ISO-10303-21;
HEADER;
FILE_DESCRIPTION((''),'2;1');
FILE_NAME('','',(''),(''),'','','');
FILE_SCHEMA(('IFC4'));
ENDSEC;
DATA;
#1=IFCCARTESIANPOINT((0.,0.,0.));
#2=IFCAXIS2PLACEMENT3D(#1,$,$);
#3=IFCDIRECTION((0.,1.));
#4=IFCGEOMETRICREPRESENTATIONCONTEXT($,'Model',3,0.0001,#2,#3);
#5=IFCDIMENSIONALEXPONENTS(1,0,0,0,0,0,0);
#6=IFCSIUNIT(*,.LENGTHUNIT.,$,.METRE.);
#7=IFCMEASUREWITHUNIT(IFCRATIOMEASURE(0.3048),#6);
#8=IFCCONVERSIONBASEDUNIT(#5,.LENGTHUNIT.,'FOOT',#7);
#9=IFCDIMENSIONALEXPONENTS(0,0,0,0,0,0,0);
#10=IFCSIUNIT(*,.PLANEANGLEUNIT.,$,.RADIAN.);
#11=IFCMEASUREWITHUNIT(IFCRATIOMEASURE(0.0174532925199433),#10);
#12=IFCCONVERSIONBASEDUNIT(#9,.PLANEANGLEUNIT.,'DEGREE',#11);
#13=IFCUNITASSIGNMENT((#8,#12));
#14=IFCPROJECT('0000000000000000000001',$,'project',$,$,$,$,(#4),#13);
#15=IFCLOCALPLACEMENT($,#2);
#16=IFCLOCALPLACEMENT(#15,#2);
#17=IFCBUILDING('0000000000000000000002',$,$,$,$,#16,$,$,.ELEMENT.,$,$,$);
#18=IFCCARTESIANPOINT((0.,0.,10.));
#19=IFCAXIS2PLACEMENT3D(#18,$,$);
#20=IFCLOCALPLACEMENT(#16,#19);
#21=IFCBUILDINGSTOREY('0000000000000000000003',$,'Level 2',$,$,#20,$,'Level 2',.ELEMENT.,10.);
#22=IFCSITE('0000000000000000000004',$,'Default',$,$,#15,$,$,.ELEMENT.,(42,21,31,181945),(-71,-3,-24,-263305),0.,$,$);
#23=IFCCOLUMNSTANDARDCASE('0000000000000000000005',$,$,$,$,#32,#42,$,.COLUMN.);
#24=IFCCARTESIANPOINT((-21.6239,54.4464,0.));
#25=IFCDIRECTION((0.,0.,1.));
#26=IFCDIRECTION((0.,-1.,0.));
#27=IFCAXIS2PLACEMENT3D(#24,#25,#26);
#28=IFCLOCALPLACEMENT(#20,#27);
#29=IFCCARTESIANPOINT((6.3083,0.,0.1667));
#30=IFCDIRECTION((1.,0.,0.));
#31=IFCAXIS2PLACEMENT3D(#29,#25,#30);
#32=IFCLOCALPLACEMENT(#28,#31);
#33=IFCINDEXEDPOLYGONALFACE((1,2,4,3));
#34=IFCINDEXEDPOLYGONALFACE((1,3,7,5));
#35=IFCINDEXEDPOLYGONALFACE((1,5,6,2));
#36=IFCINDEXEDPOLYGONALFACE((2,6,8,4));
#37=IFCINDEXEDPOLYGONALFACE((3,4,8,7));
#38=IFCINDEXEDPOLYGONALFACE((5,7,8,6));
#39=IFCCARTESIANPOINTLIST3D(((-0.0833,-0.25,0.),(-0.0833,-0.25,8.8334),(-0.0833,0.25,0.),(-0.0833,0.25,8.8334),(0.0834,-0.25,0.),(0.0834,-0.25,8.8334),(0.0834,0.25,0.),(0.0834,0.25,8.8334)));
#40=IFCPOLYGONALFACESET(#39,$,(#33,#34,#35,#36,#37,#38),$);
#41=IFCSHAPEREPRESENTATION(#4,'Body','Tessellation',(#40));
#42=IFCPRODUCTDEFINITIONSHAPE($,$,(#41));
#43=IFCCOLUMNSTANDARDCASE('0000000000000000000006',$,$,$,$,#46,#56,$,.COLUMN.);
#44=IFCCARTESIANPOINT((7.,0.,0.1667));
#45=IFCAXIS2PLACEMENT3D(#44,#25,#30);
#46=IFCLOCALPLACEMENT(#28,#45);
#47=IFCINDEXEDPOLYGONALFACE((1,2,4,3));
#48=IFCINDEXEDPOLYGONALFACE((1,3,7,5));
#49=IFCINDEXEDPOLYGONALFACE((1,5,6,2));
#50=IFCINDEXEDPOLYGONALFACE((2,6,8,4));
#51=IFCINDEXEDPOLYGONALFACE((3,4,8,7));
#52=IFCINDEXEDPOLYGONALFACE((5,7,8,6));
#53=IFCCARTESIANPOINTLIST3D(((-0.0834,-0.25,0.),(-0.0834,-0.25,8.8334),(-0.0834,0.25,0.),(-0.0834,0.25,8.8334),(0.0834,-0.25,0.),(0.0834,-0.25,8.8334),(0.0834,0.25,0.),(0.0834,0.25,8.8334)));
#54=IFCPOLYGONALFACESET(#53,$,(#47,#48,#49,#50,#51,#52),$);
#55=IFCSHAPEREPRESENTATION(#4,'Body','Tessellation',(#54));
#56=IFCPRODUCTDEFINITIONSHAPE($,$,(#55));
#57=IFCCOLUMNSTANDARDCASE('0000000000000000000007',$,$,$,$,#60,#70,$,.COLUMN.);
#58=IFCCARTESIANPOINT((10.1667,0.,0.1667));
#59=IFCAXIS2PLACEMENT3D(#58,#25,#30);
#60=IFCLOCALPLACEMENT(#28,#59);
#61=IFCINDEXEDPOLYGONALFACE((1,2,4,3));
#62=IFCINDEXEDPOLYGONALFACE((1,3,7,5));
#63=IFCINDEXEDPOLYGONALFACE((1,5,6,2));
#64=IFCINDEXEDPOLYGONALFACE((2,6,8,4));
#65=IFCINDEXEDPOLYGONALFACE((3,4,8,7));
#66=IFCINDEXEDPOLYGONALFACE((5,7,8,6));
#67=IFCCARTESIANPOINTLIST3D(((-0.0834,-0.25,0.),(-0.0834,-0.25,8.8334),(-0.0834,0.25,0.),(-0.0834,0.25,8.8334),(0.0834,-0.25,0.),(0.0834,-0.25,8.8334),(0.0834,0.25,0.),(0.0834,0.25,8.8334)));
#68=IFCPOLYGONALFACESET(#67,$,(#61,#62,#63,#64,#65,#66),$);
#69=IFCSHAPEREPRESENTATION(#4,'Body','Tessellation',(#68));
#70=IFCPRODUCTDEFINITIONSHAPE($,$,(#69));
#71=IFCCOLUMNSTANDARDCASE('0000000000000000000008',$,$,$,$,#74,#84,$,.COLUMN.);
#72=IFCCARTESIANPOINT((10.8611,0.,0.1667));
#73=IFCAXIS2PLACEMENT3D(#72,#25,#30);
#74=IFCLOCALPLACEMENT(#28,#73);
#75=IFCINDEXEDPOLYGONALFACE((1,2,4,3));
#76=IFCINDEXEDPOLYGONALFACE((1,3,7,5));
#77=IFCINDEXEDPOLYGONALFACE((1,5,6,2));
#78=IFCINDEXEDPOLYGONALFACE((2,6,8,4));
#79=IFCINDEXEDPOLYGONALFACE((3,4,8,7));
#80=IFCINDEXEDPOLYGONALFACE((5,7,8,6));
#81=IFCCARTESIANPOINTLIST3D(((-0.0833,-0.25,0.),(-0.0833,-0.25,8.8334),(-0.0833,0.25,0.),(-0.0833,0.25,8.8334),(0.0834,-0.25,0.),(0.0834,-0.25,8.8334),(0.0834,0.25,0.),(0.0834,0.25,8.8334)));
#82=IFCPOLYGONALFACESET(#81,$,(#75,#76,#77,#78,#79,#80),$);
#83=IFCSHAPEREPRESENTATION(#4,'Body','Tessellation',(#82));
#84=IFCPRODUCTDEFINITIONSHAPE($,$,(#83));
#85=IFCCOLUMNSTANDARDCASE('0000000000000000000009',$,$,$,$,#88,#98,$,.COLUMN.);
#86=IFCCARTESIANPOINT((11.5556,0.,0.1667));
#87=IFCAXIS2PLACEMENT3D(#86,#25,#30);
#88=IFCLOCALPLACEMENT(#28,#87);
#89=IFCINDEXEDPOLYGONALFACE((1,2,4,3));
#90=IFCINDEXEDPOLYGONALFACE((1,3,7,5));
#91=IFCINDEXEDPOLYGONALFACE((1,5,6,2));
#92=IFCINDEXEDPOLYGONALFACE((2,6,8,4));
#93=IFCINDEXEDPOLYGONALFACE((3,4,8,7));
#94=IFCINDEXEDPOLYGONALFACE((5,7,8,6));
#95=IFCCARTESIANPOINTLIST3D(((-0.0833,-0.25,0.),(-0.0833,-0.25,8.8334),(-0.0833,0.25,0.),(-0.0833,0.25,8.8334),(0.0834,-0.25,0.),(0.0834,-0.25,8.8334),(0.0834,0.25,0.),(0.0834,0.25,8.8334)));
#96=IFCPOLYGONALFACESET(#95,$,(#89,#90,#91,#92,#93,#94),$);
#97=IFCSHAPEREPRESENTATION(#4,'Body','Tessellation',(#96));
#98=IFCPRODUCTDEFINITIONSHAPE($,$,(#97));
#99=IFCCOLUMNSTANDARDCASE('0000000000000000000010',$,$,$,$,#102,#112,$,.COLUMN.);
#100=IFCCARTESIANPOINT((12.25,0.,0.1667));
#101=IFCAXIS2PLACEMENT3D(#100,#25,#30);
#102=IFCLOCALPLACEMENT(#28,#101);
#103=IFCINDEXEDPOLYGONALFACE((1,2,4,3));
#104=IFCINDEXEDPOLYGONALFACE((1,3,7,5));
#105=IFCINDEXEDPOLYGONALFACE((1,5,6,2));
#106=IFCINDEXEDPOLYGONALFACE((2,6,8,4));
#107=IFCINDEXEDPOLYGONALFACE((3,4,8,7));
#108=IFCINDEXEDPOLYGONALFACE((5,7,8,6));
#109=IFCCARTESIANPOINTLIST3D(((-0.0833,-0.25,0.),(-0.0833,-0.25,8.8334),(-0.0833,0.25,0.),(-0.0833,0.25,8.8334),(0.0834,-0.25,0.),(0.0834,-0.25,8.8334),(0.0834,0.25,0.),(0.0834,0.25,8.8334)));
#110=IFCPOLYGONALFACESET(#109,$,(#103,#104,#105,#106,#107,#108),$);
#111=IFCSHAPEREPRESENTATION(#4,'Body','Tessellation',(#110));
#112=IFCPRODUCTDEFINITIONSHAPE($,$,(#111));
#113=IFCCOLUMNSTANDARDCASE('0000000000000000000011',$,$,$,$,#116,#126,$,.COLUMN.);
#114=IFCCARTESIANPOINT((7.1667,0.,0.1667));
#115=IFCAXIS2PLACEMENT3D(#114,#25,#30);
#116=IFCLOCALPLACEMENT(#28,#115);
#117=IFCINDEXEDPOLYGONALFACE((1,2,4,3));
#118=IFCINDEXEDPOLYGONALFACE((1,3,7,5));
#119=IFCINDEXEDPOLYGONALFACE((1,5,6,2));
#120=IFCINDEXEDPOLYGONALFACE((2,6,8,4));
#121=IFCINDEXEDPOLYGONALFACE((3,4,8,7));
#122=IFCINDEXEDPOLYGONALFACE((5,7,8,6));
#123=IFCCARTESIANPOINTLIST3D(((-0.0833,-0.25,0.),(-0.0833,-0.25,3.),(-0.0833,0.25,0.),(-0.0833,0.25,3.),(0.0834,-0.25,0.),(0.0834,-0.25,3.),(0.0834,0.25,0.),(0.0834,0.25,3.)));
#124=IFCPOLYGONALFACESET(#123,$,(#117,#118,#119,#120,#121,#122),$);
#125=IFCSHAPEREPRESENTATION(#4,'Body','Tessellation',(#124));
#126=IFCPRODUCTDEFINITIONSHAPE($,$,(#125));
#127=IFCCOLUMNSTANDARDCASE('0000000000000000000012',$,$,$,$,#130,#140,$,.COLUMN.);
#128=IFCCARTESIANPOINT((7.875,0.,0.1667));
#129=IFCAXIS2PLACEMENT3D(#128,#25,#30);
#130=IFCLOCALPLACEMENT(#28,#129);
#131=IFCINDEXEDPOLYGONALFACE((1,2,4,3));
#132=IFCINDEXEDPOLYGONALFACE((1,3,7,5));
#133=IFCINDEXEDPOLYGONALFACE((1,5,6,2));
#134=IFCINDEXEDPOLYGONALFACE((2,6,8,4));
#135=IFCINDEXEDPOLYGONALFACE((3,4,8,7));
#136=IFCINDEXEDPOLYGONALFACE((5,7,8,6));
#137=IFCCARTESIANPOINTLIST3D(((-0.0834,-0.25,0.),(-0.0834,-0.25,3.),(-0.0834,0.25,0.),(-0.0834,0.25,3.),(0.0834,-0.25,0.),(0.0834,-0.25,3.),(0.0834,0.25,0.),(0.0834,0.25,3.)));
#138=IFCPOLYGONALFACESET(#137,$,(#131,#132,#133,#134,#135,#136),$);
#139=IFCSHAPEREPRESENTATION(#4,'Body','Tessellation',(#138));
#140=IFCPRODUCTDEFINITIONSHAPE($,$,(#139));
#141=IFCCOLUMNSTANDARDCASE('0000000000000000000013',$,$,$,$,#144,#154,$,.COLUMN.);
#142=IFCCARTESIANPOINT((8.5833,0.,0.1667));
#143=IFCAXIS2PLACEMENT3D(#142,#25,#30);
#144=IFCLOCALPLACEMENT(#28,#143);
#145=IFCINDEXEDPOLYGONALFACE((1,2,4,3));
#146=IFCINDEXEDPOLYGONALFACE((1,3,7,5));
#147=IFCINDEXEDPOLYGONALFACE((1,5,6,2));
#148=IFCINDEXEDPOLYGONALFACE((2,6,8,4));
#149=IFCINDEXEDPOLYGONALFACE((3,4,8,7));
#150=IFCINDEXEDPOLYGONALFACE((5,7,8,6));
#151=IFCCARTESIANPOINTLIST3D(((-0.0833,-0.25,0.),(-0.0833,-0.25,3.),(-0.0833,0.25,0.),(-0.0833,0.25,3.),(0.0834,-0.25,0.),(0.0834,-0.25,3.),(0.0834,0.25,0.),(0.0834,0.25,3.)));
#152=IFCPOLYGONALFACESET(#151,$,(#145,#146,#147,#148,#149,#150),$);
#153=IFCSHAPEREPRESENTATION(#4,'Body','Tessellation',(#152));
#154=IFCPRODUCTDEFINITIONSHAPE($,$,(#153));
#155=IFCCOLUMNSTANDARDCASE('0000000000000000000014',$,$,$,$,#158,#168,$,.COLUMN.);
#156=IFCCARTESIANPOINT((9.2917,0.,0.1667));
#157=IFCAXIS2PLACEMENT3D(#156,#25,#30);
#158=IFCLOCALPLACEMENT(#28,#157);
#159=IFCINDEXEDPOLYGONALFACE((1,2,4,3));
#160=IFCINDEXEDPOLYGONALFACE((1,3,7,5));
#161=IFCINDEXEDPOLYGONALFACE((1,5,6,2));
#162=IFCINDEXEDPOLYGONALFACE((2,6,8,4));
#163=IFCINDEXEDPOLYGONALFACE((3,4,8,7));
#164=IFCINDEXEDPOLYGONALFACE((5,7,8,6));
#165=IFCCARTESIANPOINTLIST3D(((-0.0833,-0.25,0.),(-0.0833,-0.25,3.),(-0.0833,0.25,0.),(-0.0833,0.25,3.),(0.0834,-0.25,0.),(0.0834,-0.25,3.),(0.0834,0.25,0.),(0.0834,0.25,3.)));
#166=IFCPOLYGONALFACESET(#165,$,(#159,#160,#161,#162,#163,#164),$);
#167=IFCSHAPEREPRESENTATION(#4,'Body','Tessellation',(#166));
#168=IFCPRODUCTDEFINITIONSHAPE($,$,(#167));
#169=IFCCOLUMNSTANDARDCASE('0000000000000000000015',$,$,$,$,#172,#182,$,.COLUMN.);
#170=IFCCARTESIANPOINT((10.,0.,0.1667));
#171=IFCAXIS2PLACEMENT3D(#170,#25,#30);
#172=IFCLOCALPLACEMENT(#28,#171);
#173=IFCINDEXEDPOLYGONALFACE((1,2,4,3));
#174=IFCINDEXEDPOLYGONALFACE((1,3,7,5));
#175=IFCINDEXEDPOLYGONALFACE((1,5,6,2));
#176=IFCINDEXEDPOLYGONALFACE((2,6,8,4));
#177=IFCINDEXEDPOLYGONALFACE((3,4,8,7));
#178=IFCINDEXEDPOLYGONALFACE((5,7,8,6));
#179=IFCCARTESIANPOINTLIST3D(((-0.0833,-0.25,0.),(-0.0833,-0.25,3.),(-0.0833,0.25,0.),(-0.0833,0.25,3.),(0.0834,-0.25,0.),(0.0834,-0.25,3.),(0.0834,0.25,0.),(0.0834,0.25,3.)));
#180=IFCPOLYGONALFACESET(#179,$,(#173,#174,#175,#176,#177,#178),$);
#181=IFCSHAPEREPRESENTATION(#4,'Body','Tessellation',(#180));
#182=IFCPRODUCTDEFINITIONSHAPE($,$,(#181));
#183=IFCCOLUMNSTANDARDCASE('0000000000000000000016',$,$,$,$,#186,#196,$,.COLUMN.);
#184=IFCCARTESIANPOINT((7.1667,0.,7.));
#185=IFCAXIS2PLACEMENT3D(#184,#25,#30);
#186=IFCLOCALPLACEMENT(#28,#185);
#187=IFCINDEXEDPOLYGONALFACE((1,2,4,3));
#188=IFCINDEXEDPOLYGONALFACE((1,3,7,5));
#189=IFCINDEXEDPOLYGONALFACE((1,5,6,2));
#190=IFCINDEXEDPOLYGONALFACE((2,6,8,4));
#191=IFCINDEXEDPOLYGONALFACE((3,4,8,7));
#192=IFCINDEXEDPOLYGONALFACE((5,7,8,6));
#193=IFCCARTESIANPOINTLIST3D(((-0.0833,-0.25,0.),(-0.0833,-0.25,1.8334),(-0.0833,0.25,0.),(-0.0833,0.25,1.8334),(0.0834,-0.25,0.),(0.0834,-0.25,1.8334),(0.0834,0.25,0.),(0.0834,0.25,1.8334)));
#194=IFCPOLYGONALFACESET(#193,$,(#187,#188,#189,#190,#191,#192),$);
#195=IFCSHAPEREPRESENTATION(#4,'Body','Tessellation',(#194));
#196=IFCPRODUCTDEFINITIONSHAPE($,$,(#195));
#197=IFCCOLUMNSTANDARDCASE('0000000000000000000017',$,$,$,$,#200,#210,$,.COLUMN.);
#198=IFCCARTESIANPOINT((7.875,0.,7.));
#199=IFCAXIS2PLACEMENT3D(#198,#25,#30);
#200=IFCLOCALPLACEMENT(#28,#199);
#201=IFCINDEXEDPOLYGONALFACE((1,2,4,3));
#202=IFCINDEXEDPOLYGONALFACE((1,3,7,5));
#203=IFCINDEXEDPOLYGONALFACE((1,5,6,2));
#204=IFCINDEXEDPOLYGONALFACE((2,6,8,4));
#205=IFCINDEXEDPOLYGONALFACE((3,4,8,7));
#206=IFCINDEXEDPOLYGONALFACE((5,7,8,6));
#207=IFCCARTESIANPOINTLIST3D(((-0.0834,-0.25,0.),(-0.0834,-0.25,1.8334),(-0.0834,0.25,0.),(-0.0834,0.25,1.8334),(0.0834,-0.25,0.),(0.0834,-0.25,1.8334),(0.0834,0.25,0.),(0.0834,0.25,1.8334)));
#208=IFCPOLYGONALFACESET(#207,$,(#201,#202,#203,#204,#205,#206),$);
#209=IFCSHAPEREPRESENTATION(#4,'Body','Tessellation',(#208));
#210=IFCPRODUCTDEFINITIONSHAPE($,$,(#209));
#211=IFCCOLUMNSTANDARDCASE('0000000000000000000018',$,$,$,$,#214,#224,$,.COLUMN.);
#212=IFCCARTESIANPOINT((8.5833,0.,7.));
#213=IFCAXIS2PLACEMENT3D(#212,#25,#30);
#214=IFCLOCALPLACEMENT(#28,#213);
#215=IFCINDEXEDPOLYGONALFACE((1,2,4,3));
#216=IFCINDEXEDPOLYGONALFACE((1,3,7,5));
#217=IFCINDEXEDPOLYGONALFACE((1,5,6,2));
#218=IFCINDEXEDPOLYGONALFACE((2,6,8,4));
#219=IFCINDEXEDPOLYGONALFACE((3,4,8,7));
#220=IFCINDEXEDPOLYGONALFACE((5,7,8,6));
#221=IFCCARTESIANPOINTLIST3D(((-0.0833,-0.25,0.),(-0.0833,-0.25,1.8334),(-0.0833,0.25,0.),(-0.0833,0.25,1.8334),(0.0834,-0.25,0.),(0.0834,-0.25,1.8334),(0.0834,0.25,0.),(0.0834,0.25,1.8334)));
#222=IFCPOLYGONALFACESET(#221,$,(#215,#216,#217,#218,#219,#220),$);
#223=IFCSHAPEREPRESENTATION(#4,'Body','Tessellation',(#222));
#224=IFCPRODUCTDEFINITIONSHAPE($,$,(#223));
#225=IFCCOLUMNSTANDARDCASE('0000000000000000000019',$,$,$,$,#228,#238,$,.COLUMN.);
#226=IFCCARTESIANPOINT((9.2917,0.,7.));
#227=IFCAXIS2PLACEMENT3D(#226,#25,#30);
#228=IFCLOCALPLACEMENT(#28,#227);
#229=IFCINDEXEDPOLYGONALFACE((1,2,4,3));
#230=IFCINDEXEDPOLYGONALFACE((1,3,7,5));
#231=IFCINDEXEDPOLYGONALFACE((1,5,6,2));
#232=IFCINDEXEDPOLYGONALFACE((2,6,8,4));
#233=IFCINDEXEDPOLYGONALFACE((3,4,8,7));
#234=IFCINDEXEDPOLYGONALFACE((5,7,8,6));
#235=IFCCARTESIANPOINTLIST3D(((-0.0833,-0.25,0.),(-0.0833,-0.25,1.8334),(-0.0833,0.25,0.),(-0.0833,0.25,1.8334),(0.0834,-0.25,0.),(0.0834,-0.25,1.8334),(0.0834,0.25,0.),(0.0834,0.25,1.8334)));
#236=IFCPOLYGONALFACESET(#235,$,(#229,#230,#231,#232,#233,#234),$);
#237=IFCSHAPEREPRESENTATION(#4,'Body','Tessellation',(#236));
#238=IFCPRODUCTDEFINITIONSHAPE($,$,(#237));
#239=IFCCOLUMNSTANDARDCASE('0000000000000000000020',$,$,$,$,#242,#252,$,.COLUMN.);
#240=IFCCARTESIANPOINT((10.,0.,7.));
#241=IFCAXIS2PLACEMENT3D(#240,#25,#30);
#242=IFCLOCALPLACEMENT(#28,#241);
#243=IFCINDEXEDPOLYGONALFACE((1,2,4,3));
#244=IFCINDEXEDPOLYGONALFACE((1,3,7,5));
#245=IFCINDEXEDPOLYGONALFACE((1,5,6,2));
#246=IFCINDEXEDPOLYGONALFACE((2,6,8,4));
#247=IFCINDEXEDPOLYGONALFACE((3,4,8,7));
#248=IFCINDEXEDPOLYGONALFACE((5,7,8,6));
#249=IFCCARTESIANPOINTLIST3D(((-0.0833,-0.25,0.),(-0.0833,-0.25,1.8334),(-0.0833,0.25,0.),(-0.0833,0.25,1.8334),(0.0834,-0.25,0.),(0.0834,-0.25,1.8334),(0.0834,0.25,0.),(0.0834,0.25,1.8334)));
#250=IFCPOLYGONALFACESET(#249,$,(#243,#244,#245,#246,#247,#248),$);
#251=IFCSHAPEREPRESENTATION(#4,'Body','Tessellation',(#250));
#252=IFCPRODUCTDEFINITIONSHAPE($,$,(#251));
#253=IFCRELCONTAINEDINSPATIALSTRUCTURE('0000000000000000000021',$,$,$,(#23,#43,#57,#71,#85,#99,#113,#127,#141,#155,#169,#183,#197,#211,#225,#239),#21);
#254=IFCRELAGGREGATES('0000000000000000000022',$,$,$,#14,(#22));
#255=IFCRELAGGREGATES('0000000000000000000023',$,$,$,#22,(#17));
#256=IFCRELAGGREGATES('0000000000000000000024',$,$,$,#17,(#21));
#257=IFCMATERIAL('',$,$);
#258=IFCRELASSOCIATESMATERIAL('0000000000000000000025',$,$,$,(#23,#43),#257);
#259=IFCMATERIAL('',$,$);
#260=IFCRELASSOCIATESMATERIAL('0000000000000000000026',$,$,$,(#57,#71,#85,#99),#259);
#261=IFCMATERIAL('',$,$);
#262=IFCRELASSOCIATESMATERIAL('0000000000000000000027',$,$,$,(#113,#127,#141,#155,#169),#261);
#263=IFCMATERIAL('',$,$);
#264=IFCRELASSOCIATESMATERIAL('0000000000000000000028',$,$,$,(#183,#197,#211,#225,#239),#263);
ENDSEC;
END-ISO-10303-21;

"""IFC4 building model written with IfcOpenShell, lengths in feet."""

from ifc_helpers import new_model, entity, si_unit, converted_unit, direction, frame, origin, place, context, project, spatial, rectangle, extrude, material, element, save


model = new_model("IFC4")

# Units and contexts
model_context = context("Model", 3, precision=0.0001, world=origin(), true_north=direction((0.0, 1.0)))
ifc_project = project(units=[converted_unit("LENGTHUNIT", "FOOT", entity("IfcRatioMeasure", 0.3048), si_unit("LENGTHUNIT", "METRE"), dimensions=[1, 0, 0, 0, 0, 0, 0]), converted_unit("PLANEANGLEUNIT", "DEGREE", entity("IfcRatioMeasure", 0.0174532925199433), si_unit("PLANEANGLEUNIT", "RADIAN"), dimensions=[0, 0, 0, 0, 0, 0, 0])], contexts=[model_context])

# Site, building, storey
site_placement = place(None, origin())
site = spatial("IfcSite", under=ifc_project, at=site_placement, Name="Default", CompositionType="ELEMENT", RefLatitude=(42, 21, 31, 181945), RefLongitude=(-71, -3, -24, -263305), RefElevation=0.0)
building_placement = place(site_placement, origin())
building = spatial("IfcBuilding", under=site, at=building_placement, CompositionType="ELEMENT")
storey_placement = place(building_placement, frame((0.0, 0.0, 10.0)))
storey = spatial("IfcBuildingStorey", under=building, at=storey_placement, Name="Level 2", LongName="Level 2", CompositionType="ELEMENT", Elevation=10.0)

# Columns
ifc_material_1 = material(Name="")
placement_1 = place(storey_placement, frame((-21.6239, 54.4464, 0.0), z_axis=(0.0, 0.0, 1.0), x_axis=(0.0, -1.0, 0.0)))
for number, where, z_axis, x_axis in (
    (1, (6.3083, 0.0, 0.1667), (0.0, 0.0, 1.0), (1.0, 0.0, 0.0)),
    (2, (7.0, 0.0, 0.1667), (0.0, 0.0, 1.0), (1.0, 0.0, 0.0)),
):
    element("IfcColumnStandardCase", number, at=place(placement_1, frame(where, z_axis=z_axis, x_axis=x_axis)), inside=storey, material=ifc_material_1, PredefinedType="COLUMN", context=model_context, shape_type="SweptSolid", body=[
        extrude(rectangle(XDim=0.1667, YDim=0.5), origin(), (0.0, 0.0, 1.0), 8.8334),
    ])
ifc_material_2 = material(Name="")
for number, where, z_axis, x_axis in (
    (3, (10.1667, 0.0, 0.1667), (0.0, 0.0, 1.0), (1.0, 0.0, 0.0)),
    (4, (10.8611, 0.0, 0.1667), (0.0, 0.0, 1.0), (1.0, 0.0, 0.0)),
    (5, (11.5556, 0.0, 0.1667), (0.0, 0.0, 1.0), (1.0, 0.0, 0.0)),
    (6, (12.25, 0.0, 0.1667), (0.0, 0.0, 1.0), (1.0, 0.0, 0.0)),
):
    element("IfcColumnStandardCase", number, at=place(placement_1, frame(where, z_axis=z_axis, x_axis=x_axis)), inside=storey, material=ifc_material_2, PredefinedType="COLUMN", context=model_context, shape_type="SweptSolid", body=[
        extrude(rectangle(XDim=0.1667, YDim=0.5), origin(), (0.0, 0.0, 1.0), 8.8334),
    ])
ifc_material_3 = material(Name="")
for number, where, z_axis, x_axis in (
    (7, (7.1667, 0.0, 0.1667), (0.0, 0.0, 1.0), (1.0, 0.0, 0.0)),
    (8, (7.875, 0.0, 0.1667), (0.0, 0.0, 1.0), (1.0, 0.0, 0.0)),
    (9, (8.5833, 0.0, 0.1667), (0.0, 0.0, 1.0), (1.0, 0.0, 0.0)),
    (10, (9.2917, 0.0, 0.1667), (0.0, 0.0, 1.0), (1.0, 0.0, 0.0)),
    (11, (10.0, 0.0, 0.1667), (0.0, 0.0, 1.0), (1.0, 0.0, 0.0)),
):
    element("IfcColumnStandardCase", number, at=place(placement_1, frame(where, z_axis=z_axis, x_axis=x_axis)), inside=storey, material=ifc_material_3, PredefinedType="COLUMN", context=model_context, shape_type="SweptSolid", body=[
        extrude(rectangle(XDim=0.1667, YDim=0.5), origin(), (0.0, 0.0, 1.0), 3.0),
    ])
ifc_material_4 = material(Name="")
for number, where, z_axis, x_axis in (
    (12, (7.1667, 0.0, 7.0), (0.0, 0.0, 1.0), (1.0, 0.0, 0.0)),
    (13, (7.875, 0.0, 7.0), (0.0, 0.0, 1.0), (1.0, 0.0, 0.0)),
    (14, (8.5833, 0.0, 7.0), (0.0, 0.0, 1.0), (1.0, 0.0, 0.0)),
    (15, (9.2917, 0.0, 7.0), (0.0, 0.0, 1.0), (1.0, 0.0, 0.0)),
    (16, (10.0, 0.0, 7.0), (0.0, 0.0, 1.0), (1.0, 0.0, 0.0)),
):
    element("IfcColumnStandardCase", number, at=place(placement_1, frame(where, z_axis=z_axis, x_axis=x_axis)), inside=storey, material=ifc_material_4, PredefinedType="COLUMN", context=model_context, shape_type="SweptSolid", body=[
        extrude(rectangle(XDim=0.1667, YDim=0.5), origin(), (0.0, 0.0, 1.0), 1.8334),
    ])

save(model, "model.ifc")
